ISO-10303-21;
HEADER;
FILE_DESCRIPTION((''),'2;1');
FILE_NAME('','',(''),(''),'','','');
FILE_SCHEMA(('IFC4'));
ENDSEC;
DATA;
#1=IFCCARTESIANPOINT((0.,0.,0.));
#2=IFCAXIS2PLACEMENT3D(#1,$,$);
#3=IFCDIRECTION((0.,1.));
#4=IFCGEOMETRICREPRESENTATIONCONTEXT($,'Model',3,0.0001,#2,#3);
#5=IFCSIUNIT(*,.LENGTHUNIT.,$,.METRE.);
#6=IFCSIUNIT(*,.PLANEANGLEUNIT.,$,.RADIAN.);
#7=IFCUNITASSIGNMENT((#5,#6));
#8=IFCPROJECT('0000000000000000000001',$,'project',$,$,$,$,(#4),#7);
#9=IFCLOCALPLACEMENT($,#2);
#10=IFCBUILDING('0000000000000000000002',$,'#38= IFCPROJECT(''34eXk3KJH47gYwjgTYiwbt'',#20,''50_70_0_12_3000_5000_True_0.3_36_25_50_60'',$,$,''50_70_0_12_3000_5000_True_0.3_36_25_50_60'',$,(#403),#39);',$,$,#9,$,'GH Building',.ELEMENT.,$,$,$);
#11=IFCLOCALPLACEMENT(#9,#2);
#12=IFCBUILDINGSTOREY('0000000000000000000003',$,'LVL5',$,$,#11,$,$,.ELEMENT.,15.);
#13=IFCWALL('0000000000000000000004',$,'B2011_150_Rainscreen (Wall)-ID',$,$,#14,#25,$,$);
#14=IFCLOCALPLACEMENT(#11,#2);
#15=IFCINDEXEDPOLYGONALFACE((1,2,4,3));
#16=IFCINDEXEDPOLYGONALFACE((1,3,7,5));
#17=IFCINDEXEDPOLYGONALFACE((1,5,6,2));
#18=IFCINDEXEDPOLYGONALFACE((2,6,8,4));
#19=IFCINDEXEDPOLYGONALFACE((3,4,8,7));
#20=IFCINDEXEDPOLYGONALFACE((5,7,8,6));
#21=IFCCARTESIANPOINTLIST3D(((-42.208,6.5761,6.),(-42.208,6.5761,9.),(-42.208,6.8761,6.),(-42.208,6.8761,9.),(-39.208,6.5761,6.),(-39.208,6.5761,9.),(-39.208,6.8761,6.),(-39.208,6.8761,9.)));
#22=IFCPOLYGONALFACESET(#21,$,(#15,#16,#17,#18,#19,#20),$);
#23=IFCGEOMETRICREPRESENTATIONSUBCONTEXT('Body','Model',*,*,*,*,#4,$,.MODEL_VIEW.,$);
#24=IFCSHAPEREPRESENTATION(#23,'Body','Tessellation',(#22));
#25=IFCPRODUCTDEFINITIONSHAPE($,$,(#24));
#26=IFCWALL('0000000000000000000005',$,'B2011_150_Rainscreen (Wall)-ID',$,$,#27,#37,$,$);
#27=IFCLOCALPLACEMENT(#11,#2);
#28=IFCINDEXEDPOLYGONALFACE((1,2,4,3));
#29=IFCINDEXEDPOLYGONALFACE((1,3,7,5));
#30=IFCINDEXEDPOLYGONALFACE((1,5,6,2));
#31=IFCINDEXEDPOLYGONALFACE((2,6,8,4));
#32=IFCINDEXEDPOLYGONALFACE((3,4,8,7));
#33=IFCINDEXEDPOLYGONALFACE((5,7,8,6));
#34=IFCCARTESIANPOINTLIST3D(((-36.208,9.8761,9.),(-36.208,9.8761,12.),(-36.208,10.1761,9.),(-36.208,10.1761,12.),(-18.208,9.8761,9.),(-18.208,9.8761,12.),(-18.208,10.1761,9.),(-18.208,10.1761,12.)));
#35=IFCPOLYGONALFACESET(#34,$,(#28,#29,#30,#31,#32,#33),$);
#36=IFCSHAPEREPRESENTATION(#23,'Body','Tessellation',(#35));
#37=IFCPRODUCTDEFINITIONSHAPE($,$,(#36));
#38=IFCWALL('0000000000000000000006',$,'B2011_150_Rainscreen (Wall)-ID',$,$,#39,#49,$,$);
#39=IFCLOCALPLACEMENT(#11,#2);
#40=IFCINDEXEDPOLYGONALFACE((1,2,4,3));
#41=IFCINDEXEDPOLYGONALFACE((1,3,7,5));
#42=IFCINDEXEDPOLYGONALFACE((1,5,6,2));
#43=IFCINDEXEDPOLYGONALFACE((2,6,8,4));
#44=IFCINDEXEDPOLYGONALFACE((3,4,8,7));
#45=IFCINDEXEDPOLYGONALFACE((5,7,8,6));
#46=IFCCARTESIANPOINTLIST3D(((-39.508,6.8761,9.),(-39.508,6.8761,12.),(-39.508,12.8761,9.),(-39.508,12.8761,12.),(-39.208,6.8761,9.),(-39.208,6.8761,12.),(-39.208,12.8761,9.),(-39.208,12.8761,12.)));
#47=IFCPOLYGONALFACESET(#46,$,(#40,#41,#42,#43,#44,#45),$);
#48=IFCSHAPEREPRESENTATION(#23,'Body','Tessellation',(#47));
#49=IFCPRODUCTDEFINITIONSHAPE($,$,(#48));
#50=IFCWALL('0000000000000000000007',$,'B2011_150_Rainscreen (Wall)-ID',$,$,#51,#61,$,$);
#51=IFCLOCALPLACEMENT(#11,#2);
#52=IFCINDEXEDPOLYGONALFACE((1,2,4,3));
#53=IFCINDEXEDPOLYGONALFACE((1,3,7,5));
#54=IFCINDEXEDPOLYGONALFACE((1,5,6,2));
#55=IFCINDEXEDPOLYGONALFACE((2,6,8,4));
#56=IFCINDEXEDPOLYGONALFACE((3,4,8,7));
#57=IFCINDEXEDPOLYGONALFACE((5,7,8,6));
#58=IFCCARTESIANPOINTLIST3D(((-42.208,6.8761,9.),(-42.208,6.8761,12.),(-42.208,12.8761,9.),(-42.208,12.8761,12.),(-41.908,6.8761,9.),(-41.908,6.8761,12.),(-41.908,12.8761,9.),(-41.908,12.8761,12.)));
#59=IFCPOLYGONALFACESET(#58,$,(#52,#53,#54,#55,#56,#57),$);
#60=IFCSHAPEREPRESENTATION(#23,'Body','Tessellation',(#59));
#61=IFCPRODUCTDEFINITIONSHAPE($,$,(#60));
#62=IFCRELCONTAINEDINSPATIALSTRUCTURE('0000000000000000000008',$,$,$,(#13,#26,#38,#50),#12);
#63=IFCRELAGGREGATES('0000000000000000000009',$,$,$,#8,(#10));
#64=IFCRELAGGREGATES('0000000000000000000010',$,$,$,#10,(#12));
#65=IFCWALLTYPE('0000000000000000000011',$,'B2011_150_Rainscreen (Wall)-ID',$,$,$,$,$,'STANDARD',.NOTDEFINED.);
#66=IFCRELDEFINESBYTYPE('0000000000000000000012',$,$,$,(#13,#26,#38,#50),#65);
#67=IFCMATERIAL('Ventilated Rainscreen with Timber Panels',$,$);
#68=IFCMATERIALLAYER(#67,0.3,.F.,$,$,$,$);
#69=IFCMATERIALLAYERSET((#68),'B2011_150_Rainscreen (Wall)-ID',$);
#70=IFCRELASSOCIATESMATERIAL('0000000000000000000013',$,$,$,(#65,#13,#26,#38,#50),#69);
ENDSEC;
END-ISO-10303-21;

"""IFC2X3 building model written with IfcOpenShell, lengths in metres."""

from ifc_helpers import new_model, si_unit, direction, frame, frame_2d, origin, place, context, subcontext, project, spatial, rectangle, extrude, material, layer, layer_set, layer_usage, type_object, element, save


model = new_model("IFC2X3")

# Units and contexts
model_context = context("Model", 3, precision=0.0001, world=origin(), true_north=direction((0.0, 1.0)))
body_context = subcontext(model_context, "Body", "Model", "MODEL_VIEW")
ifc_project = project(units=[si_unit("LENGTHUNIT", "METRE"), si_unit("PLANEANGLEUNIT", "RADIAN")], contexts=[model_context])

# Building, storey
building_placement = place(None, origin())
building = spatial("IfcBuilding", under=ifc_project, at=building_placement, Name="#38= IFCPROJECT('34eXk3KJH47gYwjgTYiwbt',#20,'50_70_0_12_3000_5000_True_0.3_36_25_50_60',$,$,'50_70_0_12_3000_5000_True_0.3_36_25_50_60',$,(#403),#39);", LongName="GH Building", CompositionType="ELEMENT")
storey_placement = place(building_placement, origin())
storey = spatial("IfcBuildingStorey", under=building, at=storey_placement, Name="LVL5", CompositionType="ELEMENT", Elevation=15.0)

# Walls
ifc_material_1 = material(Name="Ventilated Rainscreen with Timber Panels")
ifc_layer_1 = layer(ifc_material_1, 0.3, ventilated=False)
ifc_layer_set_1 = layer_set([ifc_layer_1], Name="B2011_150_Rainscreen (Wall)-ID")
wall_type = type_object("IfcWallType", Name="B2011_150_Rainscreen (Wall)-ID", ElementType="STANDARD", PredefinedType="NOTDEFINED", material=ifc_layer_set_1)
ifc_layer_usage_1 = layer_usage(ifc_layer_set_1, "AXIS2", "POSITIVE", 0.0)
wall_1_placement = place(storey_placement, frame((-39.208, 6.8761, 6.0), z_axis=(0.0, 0.0, 1.0), x_axis=(-1.0, 0.0, 0.0)))
element("IfcWall", 1, at=wall_1_placement, inside=storey, type_object=wall_type, material=ifc_layer_usage_1, Name="B2011_150_Rainscreen (Wall)-ID", context=body_context, shape_type="SweptSolid", body=[
    extrude(rectangle(XDim=3.0, YDim=0.3, at=frame_2d((1.5, 0.15))), origin(), (0.0, 0.0, 1.0), 3.0),
])
ifc_layer_usage_2 = layer_usage(ifc_layer_set_1, "AXIS2", "POSITIVE", 0.0)
wall_2_placement = place(storey_placement, frame((-36.208, 9.8761, 9.0)))
element("IfcWall", 2, at=wall_2_placement, inside=storey, type_object=wall_type, material=ifc_layer_usage_2, Name="B2011_150_Rainscreen (Wall)-ID", context=body_context, shape_type="SweptSolid", body=[
    extrude(rectangle(XDim=18.0, YDim=0.3, at=frame_2d((9.0, 0.15))), origin(), (0.0, 0.0, 1.0), 3.0),
])
ifc_layer_usage_3 = layer_usage(ifc_layer_set_1, "AXIS2", "POSITIVE", 0.0)
wall_3_placement = place(storey_placement, frame((-39.208, 6.8761, 9.0), z_axis=(0.0, 0.0, 1.0), x_axis=(0.0, 1.0, 0.0)))
element("IfcWall", 3, at=wall_3_placement, inside=storey, type_object=wall_type, material=ifc_layer_usage_3, Name="B2011_150_Rainscreen (Wall)-ID", context=body_context, shape_type="SweptSolid", body=[
    extrude(rectangle(XDim=6.0, YDim=0.3, at=frame_2d((3.0, 0.15))), origin(), (0.0, 0.0, 1.0), 3.0),
])
ifc_layer_usage_4 = layer_usage(ifc_layer_set_1, "AXIS2", "POSITIVE", 0.0)
wall_4_placement = place(storey_placement, frame((-42.208, 12.8761, 9.0), z_axis=(0.0, 0.0, 1.0), x_axis=(0.0, -1.0, 0.0)))
element("IfcWall", 4, at=wall_4_placement, inside=storey, type_object=wall_type, material=ifc_layer_usage_4, Name="B2011_150_Rainscreen (Wall)-ID", context=body_context, shape_type="SweptSolid", body=[
    extrude(rectangle(XDim=6.0, YDim=0.3, at=frame_2d((3.0, 0.15))), origin(), (0.0, 0.0, 1.0), 3.0),
])

save(model, "model.ifc")
